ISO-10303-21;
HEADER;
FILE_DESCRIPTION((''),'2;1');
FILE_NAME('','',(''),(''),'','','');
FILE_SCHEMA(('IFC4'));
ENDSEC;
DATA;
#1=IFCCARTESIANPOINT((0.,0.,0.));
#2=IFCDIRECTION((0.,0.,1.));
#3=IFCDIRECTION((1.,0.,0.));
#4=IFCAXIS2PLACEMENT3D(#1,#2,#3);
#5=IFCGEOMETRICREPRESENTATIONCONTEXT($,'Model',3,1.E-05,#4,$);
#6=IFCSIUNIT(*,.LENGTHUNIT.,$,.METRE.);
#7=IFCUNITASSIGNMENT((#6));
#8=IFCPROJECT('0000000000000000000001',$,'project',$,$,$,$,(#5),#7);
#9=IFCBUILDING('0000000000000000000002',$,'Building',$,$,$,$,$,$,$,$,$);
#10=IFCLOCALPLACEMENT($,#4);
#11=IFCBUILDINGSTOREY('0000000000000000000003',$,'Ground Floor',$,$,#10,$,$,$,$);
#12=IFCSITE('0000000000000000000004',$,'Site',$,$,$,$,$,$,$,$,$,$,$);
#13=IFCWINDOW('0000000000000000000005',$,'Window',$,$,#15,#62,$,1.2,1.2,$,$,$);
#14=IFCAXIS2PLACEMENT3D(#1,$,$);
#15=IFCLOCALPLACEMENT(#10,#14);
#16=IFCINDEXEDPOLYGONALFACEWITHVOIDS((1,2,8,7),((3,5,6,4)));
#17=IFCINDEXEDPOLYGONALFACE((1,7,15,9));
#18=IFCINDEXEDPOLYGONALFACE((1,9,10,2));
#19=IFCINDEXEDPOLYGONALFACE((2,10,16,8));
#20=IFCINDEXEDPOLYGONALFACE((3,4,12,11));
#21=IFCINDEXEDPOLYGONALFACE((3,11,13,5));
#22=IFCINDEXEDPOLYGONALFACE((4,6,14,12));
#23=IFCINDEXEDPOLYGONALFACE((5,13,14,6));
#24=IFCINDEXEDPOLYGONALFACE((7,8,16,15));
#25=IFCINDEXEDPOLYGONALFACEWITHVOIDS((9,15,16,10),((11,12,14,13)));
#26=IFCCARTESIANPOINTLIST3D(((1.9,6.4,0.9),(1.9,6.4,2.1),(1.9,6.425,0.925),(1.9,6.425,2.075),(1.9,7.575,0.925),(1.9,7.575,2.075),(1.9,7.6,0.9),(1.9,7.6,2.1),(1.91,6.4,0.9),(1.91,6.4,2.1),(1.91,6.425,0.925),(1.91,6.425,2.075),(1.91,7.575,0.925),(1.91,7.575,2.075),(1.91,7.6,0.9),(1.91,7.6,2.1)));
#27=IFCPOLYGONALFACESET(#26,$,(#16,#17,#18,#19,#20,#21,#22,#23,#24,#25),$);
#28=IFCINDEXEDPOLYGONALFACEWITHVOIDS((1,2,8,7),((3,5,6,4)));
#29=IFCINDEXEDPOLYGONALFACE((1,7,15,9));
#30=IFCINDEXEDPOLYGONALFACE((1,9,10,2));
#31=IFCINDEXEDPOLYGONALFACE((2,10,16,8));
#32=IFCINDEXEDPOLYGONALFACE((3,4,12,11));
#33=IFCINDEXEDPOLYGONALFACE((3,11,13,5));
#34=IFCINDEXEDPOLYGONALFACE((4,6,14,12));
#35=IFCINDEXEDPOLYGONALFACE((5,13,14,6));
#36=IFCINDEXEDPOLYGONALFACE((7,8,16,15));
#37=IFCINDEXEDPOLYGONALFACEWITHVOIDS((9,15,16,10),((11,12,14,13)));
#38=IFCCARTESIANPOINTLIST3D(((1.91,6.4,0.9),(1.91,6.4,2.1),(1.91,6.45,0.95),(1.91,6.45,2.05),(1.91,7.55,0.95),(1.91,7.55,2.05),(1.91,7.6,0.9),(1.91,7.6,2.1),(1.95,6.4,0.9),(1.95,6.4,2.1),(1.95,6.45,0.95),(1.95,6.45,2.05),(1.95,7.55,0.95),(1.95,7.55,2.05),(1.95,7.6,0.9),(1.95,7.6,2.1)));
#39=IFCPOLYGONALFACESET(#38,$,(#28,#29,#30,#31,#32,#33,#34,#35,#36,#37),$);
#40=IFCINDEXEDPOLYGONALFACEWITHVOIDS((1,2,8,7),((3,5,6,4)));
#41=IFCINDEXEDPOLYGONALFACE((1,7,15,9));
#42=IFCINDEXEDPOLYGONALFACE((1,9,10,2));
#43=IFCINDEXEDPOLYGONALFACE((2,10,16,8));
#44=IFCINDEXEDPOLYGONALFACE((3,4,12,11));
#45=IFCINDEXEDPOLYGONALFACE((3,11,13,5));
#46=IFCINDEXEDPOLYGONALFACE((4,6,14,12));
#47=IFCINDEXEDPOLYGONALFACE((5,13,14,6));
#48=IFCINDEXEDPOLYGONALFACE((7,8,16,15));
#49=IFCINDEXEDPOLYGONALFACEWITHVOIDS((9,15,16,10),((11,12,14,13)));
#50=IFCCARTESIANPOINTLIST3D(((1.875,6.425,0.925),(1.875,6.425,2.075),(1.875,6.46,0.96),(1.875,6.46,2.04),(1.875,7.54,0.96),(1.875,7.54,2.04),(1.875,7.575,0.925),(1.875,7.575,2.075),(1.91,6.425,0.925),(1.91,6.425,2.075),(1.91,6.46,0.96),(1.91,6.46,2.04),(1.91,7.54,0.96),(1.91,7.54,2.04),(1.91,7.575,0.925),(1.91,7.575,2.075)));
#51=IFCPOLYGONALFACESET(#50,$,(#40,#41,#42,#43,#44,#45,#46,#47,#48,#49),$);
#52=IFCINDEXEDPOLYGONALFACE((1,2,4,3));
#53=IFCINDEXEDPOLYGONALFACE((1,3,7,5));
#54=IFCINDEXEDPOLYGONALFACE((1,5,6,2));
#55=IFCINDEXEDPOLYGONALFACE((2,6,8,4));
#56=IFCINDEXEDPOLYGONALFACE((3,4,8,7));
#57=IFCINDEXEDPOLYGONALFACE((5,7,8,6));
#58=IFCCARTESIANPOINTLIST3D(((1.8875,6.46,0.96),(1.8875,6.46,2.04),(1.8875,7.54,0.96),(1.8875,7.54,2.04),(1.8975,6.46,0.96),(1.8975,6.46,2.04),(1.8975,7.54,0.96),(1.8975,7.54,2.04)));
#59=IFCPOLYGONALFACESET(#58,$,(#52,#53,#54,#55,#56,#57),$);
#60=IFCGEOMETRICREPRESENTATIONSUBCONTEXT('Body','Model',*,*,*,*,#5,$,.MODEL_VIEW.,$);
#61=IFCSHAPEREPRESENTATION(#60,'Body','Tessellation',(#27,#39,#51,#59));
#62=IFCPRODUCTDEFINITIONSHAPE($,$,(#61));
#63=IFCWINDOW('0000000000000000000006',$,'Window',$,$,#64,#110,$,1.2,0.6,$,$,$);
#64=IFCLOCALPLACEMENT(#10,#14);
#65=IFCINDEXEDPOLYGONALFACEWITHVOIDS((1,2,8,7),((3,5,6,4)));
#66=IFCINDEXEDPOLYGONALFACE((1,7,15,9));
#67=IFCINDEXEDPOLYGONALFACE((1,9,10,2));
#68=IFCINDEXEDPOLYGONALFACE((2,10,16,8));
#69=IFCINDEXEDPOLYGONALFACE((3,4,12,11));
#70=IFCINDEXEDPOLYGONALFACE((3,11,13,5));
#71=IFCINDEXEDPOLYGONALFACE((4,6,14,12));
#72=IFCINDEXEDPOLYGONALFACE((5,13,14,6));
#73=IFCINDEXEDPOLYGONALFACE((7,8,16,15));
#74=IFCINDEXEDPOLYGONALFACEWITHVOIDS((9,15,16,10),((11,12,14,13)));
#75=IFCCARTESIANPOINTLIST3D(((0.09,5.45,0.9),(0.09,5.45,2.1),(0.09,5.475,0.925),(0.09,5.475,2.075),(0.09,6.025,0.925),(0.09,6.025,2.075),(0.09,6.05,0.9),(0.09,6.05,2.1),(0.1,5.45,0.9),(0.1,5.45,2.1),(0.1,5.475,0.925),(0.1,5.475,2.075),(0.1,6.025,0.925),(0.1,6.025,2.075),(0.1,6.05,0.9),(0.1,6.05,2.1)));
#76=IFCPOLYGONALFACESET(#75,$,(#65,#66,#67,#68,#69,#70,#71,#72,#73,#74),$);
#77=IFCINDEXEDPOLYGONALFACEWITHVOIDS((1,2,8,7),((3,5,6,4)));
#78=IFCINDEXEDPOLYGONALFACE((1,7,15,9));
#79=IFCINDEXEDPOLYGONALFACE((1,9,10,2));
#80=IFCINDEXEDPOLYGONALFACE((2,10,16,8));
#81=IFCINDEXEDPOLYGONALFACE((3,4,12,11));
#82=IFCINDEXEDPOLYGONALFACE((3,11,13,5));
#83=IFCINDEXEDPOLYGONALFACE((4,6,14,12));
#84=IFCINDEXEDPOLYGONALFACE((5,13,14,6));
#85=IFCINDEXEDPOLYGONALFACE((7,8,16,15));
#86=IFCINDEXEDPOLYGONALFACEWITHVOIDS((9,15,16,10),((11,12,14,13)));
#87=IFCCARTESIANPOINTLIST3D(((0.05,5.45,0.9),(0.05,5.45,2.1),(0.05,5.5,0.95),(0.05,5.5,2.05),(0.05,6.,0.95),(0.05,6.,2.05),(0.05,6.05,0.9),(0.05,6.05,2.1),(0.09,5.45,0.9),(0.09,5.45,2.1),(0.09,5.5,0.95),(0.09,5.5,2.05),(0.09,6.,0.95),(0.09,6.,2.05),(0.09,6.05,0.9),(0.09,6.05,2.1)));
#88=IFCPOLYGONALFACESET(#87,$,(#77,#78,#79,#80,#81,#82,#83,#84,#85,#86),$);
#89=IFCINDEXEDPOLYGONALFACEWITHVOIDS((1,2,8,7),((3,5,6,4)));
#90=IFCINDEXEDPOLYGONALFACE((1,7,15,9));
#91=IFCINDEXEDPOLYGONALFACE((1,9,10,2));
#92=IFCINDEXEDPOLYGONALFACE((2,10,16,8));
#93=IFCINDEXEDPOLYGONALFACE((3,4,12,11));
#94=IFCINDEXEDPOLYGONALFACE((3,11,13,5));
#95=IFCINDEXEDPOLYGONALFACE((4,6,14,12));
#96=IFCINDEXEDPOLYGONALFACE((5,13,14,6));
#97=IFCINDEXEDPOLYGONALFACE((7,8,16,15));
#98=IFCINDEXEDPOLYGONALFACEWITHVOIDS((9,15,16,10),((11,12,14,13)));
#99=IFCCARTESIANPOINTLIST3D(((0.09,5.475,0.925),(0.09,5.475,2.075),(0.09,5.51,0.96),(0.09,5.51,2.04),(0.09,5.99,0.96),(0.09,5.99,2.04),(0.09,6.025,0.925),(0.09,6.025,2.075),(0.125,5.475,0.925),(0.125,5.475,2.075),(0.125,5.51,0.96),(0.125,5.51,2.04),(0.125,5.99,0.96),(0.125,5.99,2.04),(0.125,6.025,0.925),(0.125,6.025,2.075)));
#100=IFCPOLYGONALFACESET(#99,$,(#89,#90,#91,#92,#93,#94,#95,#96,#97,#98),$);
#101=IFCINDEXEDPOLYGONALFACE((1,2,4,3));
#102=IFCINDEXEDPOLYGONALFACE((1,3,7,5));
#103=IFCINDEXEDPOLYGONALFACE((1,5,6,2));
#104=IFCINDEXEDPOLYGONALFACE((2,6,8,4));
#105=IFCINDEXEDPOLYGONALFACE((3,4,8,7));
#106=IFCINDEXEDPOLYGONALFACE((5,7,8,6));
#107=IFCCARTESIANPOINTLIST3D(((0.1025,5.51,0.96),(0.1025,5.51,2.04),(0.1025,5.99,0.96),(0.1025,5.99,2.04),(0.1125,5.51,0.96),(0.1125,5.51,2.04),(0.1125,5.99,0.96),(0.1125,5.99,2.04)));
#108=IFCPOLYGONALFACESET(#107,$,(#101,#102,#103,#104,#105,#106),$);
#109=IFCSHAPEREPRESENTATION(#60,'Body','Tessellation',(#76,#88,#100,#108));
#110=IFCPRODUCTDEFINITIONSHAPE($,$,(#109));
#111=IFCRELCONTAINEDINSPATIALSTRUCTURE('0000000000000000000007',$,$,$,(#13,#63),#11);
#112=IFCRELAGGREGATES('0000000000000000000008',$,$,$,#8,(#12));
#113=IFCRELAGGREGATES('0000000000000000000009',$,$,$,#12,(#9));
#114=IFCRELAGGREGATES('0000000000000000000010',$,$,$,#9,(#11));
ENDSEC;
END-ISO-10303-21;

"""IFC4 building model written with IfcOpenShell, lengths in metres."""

from ifc_helpers import new_model, si_unit, frame, origin_with_axes, place, context, subcontext, project, spatial, line, indexed_curve, outline, extrude, element, save


model = new_model("IFC4")

# Units and contexts
model_context = context("Model", 3, precision=1e-05, world=origin_with_axes())
body_context = subcontext(model_context, "Body", "Model", "MODEL_VIEW")
ifc_project = project(units=[si_unit("LENGTHUNIT", "METRE")], contexts=[model_context])

# Site, building, storey
site = spatial("IfcSite", under=ifc_project, Name="Site")
building = spatial("IfcBuilding", under=site, Name="Building")
storey_placement = place(None, origin_with_axes())
storey = spatial("IfcBuildingStorey", under=building, at=storey_placement, Name="Ground Floor")

# Windows
window_1_placement = place(storey_placement, frame((2.0, 6.4, 0.9), z_axis=(0.0, 0.0, 1.0), x_axis=(0.0, 1.0, 0.0)))
element("IfcWindow", 1, at=window_1_placement, inside=storey, Name="Window", OverallHeight=1.2, OverallWidth=1.2, context=body_context, shape_type="SweptSolid", body=[
    extrude(outline(indexed_curve([(0.0, 0.0), (1.2, 0.0), (1.2, 1.2), (0.0, 1.2)], segments=[line(1, 2, 3, 4, 1)]), holes=[indexed_curve([(0.025, 0.025), (1.175, 0.025), (1.175, 1.175), (0.025, 1.175)], segments=[line(1, 2, 3, 4, 1)])]), frame((0.0, 0.09, 0.0), z_axis=(0.0, -1.0, 0.0), x_axis=(1.0, 0.0, 0.0)), (0.0, 0.0, -1.0), 0.01),
    extrude(outline(indexed_curve([(0.0, 0.0), (1.2, 0.0), (1.2, 1.2), (0.0, 1.2)], segments=[line(1, 2, 3, 4, 1)]), holes=[indexed_curve([(0.05, 0.05), (1.15, 0.05), (1.15, 1.15), (0.05, 1.15)], segments=[line(1, 2, 3, 4, 1)])]), frame((0.0, 0.05, 0.0), z_axis=(0.0, -1.0, 0.0), x_axis=(1.0, 0.0, 0.0)), (0.0, 0.0, -1.0), 0.04),
    extrude(outline(indexed_curve([(0.0, 0.0), (1.15, 0.0), (1.15, 1.15), (0.0, 1.15)], segments=[line(1, 2, 3, 4, 1)]), holes=[indexed_curve([(0.035, 0.035), (1.115, 0.035), (1.115, 1.115), (0.035, 1.115)], segments=[line(1, 2, 3, 4, 1)])]), frame((0.025, 0.09, 0.025), z_axis=(0.0, -1.0, 0.0), x_axis=(1.0, 0.0, 0.0)), (0.0, 0.0, -1.0), 0.035),
    extrude(outline(indexed_curve([(0.035, 0.035), (1.115, 0.035), (1.115, 1.115), (0.035, 1.115)], segments=[line(1, 2, 3, 4, 1)])), frame((0.025, 0.1025, 0.025), z_axis=(0.0, -1.0, 0.0), x_axis=(1.0, 0.0, 0.0)), (0.0, 0.0, -1.0), 0.01),
])
window_2_placement = place(storey_placement, frame((0.0, 6.05, 0.9), z_axis=(0.0, 0.0, 1.0), x_axis=(0.0, -1.0, 0.0)))
element("IfcWindow", 2, at=window_2_placement, inside=storey, Name="Window", OverallHeight=1.2, OverallWidth=0.6, context=body_context, shape_type="SweptSolid", body=[
    extrude(outline(indexed_curve([(0.0, 0.0), (0.6, 0.0), (0.6, 1.2), (0.0, 1.2)], segments=[line(1, 2, 3, 4, 1)]), holes=[indexed_curve([(0.025, 0.025), (0.575, 0.025), (0.575, 1.175), (0.025, 1.175)], segments=[line(1, 2, 3, 4, 1)])]), frame((0.0, 0.09, 0.0), z_axis=(0.0, -1.0, 0.0), x_axis=(1.0, 0.0, 0.0)), (0.0, 0.0, -1.0), 0.01),
    extrude(outline(indexed_curve([(0.0, 0.0), (0.6, 0.0), (0.6, 1.2), (0.0, 1.2)], segments=[line(1, 2, 3, 4, 1)]), holes=[indexed_curve([(0.05, 0.05), (0.55, 0.05), (0.55, 1.15), (0.05, 1.15)], segments=[line(1, 2, 3, 4, 1)])]), frame((0.0, 0.05, 0.0), z_axis=(0.0, -1.0, 0.0), x_axis=(1.0, 0.0, 0.0)), (0.0, 0.0, -1.0), 0.04),
    extrude(outline(indexed_curve([(0.0, 0.0), (0.55, 0.0), (0.55, 1.15), (0.0, 1.15)], segments=[line(1, 2, 3, 4, 1)]), holes=[indexed_curve([(0.035, 0.035), (0.515, 0.035), (0.515, 1.115), (0.035, 1.115)], segments=[line(1, 2, 3, 4, 1)])]), frame((0.025, 0.09, 0.025), z_axis=(0.0, -1.0, 0.0), x_axis=(1.0, 0.0, 0.0)), (0.0, 0.0, -1.0), 0.035),
    extrude(outline(indexed_curve([(0.035, 0.035), (0.515, 0.035), (0.515, 1.115), (0.035, 1.115)], segments=[line(1, 2, 3, 4, 1)])), frame((0.025, 0.1025, 0.025), z_axis=(0.0, -1.0, 0.0), x_axis=(1.0, 0.0, 0.0)), (0.0, 0.0, -1.0), 0.01),
])

save(model, "model.ifc")
